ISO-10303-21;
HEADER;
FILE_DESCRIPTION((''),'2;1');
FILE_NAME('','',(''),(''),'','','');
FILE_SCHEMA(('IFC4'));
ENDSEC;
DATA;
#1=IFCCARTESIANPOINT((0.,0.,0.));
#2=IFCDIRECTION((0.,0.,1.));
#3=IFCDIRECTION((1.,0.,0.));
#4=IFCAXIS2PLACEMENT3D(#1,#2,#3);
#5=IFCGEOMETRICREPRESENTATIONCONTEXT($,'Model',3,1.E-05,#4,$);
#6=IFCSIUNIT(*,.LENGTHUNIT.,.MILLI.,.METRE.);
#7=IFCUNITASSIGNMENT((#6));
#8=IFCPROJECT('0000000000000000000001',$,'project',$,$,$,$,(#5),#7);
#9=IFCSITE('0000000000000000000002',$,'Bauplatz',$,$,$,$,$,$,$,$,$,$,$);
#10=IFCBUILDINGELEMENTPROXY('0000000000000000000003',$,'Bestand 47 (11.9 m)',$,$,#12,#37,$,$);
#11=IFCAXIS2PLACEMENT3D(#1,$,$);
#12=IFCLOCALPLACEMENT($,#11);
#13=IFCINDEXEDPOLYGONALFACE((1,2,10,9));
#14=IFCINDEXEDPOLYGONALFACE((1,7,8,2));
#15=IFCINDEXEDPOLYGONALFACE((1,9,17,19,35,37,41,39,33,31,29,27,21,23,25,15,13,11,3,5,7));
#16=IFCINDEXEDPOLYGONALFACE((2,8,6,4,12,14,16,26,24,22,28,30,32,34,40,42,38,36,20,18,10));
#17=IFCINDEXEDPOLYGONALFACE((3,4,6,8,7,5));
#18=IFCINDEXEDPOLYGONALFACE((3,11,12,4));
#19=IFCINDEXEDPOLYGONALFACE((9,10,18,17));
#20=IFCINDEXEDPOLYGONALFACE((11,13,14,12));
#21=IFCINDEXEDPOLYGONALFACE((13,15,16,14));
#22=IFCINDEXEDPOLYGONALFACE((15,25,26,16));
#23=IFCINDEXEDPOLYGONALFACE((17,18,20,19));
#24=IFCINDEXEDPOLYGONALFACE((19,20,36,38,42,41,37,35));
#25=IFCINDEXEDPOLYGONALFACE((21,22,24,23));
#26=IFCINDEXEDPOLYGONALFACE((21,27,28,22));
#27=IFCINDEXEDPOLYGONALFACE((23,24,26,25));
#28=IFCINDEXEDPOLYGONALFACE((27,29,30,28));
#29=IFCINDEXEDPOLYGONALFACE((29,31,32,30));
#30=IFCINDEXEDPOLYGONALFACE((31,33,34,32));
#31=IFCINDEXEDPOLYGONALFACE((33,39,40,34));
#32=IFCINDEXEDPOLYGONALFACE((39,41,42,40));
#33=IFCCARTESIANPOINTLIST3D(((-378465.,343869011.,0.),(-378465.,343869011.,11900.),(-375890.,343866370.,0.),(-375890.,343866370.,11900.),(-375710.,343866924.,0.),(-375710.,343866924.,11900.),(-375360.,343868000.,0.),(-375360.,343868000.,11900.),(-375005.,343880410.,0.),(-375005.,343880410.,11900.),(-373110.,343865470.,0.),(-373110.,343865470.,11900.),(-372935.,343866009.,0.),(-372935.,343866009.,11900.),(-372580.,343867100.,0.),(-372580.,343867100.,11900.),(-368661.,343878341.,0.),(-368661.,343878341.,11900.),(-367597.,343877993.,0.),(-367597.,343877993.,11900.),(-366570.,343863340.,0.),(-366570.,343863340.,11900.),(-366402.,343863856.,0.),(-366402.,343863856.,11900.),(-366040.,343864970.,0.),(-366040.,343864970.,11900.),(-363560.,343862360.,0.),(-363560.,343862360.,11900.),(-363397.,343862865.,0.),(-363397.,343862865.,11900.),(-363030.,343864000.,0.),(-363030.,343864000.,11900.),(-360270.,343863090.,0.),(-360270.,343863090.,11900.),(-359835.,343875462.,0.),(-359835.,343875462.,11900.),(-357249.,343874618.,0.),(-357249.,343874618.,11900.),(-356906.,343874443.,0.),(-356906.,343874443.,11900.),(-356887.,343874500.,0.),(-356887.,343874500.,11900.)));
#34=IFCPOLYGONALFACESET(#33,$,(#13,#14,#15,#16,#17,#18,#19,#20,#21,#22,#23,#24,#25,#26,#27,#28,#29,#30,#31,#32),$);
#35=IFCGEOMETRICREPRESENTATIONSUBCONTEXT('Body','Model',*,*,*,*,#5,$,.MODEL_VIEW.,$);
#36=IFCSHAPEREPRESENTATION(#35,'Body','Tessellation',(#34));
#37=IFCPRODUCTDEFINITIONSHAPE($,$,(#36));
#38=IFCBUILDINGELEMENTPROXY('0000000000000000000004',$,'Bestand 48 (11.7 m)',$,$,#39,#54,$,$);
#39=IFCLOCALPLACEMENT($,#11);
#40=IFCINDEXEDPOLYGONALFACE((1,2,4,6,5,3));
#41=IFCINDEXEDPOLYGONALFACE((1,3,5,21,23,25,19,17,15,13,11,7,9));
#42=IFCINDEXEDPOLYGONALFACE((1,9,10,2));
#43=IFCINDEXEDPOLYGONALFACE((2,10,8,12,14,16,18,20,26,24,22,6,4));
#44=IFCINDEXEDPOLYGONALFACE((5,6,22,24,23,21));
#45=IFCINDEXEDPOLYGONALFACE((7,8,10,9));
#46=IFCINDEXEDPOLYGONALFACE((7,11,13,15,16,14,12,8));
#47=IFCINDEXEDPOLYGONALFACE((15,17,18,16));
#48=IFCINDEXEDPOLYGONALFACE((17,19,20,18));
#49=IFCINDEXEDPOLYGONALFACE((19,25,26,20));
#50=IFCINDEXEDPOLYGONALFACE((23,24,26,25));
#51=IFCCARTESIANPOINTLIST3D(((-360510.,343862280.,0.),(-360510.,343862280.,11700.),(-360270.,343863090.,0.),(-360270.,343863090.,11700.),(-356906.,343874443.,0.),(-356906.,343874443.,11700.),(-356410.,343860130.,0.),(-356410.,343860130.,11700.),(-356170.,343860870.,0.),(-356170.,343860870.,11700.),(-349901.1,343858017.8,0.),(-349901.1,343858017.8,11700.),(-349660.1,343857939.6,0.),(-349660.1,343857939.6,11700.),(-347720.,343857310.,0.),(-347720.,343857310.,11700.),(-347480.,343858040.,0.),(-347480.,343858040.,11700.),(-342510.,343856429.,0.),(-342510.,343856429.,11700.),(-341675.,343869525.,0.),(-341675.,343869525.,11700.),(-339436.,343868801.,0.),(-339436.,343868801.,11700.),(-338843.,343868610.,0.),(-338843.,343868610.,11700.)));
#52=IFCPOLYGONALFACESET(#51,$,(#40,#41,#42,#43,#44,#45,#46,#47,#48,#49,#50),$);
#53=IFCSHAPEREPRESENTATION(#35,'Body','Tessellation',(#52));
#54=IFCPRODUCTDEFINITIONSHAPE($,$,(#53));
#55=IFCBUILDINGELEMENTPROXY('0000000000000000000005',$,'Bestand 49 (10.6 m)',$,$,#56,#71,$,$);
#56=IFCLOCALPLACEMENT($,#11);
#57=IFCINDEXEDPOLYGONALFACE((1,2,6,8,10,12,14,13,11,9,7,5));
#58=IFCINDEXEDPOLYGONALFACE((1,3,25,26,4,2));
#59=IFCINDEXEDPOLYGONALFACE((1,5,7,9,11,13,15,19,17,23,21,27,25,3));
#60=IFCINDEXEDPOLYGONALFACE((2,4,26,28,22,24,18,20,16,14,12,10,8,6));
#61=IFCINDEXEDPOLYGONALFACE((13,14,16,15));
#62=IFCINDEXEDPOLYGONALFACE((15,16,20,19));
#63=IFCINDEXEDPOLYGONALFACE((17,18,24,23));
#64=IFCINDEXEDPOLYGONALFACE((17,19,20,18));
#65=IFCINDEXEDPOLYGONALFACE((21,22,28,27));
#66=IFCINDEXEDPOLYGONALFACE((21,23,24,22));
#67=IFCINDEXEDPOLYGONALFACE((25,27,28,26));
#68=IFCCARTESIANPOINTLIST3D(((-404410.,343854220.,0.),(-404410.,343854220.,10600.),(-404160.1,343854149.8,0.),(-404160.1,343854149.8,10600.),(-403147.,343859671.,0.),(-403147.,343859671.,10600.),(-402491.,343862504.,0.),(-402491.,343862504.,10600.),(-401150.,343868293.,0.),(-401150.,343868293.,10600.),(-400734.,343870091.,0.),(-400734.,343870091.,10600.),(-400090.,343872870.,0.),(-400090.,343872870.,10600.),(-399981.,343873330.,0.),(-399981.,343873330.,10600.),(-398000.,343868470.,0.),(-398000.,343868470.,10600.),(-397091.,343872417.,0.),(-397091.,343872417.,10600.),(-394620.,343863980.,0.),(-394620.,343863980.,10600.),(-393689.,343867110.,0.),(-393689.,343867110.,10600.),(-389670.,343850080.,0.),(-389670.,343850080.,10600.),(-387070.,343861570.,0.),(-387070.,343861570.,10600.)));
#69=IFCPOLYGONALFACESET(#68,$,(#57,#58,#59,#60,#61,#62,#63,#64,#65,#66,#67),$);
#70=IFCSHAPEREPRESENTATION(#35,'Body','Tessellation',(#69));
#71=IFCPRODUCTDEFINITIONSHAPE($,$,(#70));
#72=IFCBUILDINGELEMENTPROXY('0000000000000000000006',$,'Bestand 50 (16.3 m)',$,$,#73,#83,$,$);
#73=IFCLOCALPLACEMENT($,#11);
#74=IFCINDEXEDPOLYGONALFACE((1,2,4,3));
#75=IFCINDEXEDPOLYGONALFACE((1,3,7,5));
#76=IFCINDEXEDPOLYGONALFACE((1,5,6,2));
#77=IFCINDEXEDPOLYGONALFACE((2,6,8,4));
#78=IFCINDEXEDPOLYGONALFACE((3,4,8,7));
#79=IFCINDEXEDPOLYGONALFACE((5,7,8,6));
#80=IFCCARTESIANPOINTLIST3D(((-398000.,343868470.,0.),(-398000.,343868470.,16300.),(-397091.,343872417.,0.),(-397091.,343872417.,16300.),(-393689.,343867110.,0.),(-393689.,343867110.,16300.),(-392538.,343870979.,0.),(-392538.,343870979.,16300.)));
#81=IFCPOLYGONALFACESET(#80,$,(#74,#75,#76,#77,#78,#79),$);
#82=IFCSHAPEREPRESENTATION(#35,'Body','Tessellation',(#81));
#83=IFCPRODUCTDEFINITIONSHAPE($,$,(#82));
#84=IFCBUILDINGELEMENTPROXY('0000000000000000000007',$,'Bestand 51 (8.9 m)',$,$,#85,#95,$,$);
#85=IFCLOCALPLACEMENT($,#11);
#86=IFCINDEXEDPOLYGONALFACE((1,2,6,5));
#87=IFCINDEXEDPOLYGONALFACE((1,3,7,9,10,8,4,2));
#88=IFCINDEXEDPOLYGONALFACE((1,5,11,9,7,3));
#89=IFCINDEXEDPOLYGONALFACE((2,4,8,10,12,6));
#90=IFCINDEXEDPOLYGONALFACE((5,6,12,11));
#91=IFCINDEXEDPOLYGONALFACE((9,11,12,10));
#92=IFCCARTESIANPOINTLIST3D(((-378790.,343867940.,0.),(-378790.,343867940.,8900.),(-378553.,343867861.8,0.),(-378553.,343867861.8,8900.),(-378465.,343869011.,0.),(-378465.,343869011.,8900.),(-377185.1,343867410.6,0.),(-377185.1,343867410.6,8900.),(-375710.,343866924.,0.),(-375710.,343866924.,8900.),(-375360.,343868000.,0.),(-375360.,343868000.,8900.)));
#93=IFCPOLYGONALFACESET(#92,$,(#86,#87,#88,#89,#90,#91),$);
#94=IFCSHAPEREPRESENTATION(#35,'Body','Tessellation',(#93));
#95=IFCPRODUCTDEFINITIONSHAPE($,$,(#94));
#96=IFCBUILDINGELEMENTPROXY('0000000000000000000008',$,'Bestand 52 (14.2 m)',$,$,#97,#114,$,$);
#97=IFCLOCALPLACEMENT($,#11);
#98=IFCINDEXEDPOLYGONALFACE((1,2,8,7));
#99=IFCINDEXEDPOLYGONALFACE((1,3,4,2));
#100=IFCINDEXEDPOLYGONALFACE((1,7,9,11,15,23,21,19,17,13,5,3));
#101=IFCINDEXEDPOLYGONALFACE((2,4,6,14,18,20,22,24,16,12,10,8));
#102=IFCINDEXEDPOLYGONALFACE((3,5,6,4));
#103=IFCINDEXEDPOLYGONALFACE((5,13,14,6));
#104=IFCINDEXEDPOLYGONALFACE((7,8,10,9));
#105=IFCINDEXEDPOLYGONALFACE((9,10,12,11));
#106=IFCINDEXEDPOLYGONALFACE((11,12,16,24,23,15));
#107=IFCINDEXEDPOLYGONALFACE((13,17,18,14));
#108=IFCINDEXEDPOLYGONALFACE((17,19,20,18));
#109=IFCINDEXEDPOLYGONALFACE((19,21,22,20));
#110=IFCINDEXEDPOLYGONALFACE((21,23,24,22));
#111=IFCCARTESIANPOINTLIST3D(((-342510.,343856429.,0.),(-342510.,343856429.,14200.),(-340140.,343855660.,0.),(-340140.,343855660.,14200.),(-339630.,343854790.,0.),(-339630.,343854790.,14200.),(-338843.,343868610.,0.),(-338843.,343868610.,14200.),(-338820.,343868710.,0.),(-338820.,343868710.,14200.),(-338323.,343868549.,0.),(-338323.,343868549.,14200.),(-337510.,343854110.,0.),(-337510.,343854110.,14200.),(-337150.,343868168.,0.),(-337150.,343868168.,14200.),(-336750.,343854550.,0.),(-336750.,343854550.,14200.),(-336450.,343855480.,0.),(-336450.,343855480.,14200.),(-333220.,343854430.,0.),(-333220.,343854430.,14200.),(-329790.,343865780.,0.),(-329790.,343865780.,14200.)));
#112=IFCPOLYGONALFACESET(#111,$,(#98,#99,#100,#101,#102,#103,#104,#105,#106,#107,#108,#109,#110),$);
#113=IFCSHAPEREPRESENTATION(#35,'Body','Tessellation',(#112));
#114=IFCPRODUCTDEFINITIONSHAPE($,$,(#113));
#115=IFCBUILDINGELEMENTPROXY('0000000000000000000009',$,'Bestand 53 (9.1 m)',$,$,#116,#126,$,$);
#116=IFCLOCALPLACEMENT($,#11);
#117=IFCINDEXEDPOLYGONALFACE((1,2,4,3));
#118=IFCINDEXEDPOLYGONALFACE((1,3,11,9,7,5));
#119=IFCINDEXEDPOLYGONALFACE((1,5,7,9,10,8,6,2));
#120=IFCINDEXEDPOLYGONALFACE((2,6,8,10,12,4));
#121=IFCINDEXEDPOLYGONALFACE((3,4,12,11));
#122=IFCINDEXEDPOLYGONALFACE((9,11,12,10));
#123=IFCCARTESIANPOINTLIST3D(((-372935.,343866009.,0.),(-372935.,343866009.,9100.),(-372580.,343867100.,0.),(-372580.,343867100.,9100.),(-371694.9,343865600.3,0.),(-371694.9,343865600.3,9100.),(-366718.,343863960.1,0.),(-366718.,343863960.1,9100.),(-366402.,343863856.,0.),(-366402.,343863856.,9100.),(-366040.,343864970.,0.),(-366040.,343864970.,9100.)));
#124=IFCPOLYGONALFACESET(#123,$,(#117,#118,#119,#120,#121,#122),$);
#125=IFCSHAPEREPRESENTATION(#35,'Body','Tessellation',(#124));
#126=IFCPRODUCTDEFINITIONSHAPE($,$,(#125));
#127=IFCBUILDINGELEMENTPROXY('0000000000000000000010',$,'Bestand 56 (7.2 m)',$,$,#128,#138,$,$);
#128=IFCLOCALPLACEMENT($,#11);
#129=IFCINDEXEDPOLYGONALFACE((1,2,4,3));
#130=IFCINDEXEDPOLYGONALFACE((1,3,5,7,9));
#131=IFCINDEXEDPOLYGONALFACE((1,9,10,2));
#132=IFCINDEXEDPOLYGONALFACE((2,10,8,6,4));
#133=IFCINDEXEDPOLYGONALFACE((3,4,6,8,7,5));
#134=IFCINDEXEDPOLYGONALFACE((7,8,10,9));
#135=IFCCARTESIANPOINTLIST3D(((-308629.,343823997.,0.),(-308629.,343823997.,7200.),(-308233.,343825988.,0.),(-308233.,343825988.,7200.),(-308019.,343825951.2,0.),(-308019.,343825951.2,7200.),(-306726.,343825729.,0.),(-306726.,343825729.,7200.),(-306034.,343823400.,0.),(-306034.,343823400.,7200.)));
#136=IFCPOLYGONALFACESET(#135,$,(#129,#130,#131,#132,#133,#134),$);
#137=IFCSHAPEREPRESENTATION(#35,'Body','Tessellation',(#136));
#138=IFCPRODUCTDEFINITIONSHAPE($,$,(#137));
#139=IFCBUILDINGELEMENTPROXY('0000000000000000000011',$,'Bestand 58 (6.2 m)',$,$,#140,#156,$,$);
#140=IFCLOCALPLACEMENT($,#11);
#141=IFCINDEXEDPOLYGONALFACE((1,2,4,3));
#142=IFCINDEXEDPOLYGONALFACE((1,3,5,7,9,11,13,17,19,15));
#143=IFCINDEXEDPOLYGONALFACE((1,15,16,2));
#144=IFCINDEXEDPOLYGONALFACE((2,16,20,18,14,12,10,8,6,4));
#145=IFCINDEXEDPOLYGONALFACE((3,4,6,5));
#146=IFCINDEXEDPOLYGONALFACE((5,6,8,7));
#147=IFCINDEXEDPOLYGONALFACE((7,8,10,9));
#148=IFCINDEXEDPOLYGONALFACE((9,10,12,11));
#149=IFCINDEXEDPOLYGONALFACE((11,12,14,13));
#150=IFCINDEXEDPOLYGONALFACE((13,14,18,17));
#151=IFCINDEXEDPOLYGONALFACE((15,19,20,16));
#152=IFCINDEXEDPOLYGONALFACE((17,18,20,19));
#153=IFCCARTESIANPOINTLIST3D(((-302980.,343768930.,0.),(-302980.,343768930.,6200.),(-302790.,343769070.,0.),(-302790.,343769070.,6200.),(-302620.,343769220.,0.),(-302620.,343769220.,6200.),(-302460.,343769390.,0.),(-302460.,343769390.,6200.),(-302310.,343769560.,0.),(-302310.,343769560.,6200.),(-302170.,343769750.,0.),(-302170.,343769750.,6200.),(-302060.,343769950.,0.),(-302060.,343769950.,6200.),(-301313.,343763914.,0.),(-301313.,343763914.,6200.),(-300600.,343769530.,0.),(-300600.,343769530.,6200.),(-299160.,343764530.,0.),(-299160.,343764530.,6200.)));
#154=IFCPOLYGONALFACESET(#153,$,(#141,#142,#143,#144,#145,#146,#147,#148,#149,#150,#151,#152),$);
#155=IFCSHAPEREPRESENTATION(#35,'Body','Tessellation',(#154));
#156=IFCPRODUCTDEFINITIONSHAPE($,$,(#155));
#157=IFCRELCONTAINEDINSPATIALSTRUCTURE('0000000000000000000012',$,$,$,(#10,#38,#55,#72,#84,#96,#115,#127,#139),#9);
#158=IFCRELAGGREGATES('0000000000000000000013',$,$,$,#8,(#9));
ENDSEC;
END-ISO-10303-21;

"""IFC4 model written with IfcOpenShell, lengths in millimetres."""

from ifc_helpers import new_model, si_unit, origin_with_axes, place, context, subcontext, project, spatial, indexed_curve, outline, extrude, element, save


model = new_model("IFC4")

# Units and contexts
model_context = context("Model", 3, precision=1e-05, world=origin_with_axes())
body_context = subcontext(model_context, "Body", "Model", "MODEL_VIEW")
ifc_project = project(units=[si_unit("LENGTHUNIT", "METRE", prefix="MILLI")], contexts=[model_context])

# Site
site = spatial("IfcSite", under=ifc_project, Name="Bauplatz")

# Building element proxies
proxy_1_placement = place(None, origin_with_axes())
element("IfcBuildingElementProxy", 1, at=proxy_1_placement, inside=site, Name="Bestand 47 (11.9 m)", context=body_context, shape_type="SweptSolid", body=[
    extrude(outline(indexed_curve([(-368661.0, 343878341.0), (-375005.0, 343880410.0), (-378465.0, 343869011.0), (-375360.0, 343868000.0), (-375710.0, 343866924.0), (-375890.0, 343866370.0), (-373110.0, 343865470.0), (-372935.0, 343866009.0), (-372580.0, 343867100.0), (-366040.0, 343864970.0), (-366402.0, 343863856.0), (-366570.0, 343863340.0), (-363560.0, 343862360.0), (-363397.0, 343862865.0), (-363030.0, 343864000.0), (-360270.0, 343863090.0), (-356906.0, 343874443.0), (-356887.0, 343874500.0), (-357249.0, 343874618.0), (-359835.0, 343875462.0), (-367597.0, 343877993.0)])), None, (0.0, 0.0, 1.0), 11900.0),
])
proxy_2_placement = place(None, origin_with_axes())
element("IfcBuildingElementProxy", 2, at=proxy_2_placement, inside=site, Name="Bestand 48 (11.7 m)", context=body_context, shape_type="SweptSolid", body=[
    extrude(outline(indexed_curve([(-341675.0, 343869525.0), (-356906.0, 343874443.0), (-360270.0, 343863090.0), (-360510.0, 343862280.0), (-356170.0, 343860870.0), (-356410.0, 343860130.0), (-349901.1, 343858017.8), (-349660.1, 343857939.6), (-347720.0, 343857310.0), (-347480.0, 343858040.0), (-342510.0, 343856429.0), (-338843.0, 343868610.0), (-339436.0, 343868801.0)])), None, (0.0, 0.0, 1.0), 11700.0),
])
proxy_3_placement = place(None, origin_with_axes())
element("IfcBuildingElementProxy", 3, at=proxy_3_placement, inside=site, Name="Bestand 49 (10.6 m)", context=body_context, shape_type="SweptSolid", body=[
    extrude(outline(indexed_curve([(-397091.0, 343872417.0), (-399981.0, 343873330.0), (-400090.0, 343872870.0), (-400734.0, 343870091.0), (-401150.0, 343868293.0), (-402491.0, 343862504.0), (-403147.0, 343859671.0), (-404410.0, 343854220.0), (-404160.1, 343854149.8), (-389670.0, 343850080.0), (-387070.0, 343861570.0), (-394620.0, 343863980.0), (-393689.0, 343867110.0), (-398000.0, 343868470.0)])), None, (0.0, 0.0, 1.0), 10600.0),
])
proxy_4_placement = place(None, origin_with_axes())
element("IfcBuildingElementProxy", 4, at=proxy_4_placement, inside=site, Name="Bestand 50 (16.3 m)", context=body_context, shape_type="SweptSolid", body=[
    extrude(outline(indexed_curve([(-392538.0, 343870979.0), (-397091.0, 343872417.0), (-398000.0, 343868470.0), (-393689.0, 343867110.0)])), None, (0.0, 0.0, 1.0), 16300.0),
])
proxy_5_placement = place(None, origin_with_axes())
element("IfcBuildingElementProxy", 5, at=proxy_5_placement, inside=site, Name="Bestand 51 (8.9 m)", context=body_context, shape_type="SweptSolid", body=[
    extrude(outline(indexed_curve([(-375360.0, 343868000.0), (-378465.0, 343869011.0), (-378790.0, 343867940.0), (-378553.0, 343867861.8), (-377185.1, 343867410.6), (-375710.0, 343866924.0)])), None, (0.0, 0.0, 1.0), 8900.0),
])
proxy_6_placement = place(None, origin_with_axes())
element("IfcBuildingElementProxy", 6, at=proxy_6_placement, inside=site, Name="Bestand 52 (14.2 m)", context=body_context, shape_type="SweptSolid", body=[
    extrude(outline(indexed_curve([(-338323.0, 343868549.0), (-338820.0, 343868710.0), (-338843.0, 343868610.0), (-342510.0, 343856429.0), (-340140.0, 343855660.0), (-339630.0, 343854790.0), (-337510.0, 343854110.0), (-336750.0, 343854550.0), (-336450.0, 343855480.0), (-333220.0, 343854430.0), (-329790.0, 343865780.0), (-337150.0, 343868168.0)])), None, (0.0, 0.0, 1.0), 14200.0),
])
proxy_7_placement = place(None, origin_with_axes())
element("IfcBuildingElementProxy", 7, at=proxy_7_placement, inside=site, Name="Bestand 53 (9.1 m)", context=body_context, shape_type="SweptSolid", body=[
    extrude(outline(indexed_curve([(-366040.0, 343864970.0), (-372580.0, 343867100.0), (-372935.0, 343866009.0), (-371694.9, 343865600.3), (-366718.0, 343863960.1), (-366402.0, 343863856.0)])), None, (0.0, 0.0, 1.0), 9100.0),
])
proxy_8_placement = place(None, origin_with_axes())
element("IfcBuildingElementProxy", 8, at=proxy_8_placement, inside=site, Name="Bestand 56 (7.2 m)", context=body_context, shape_type="SweptSolid", body=[
    extrude(outline(indexed_curve([(-308019.0, 343825951.2), (-308233.0, 343825988.0), (-308629.0, 343823997.0), (-306034.0, 343823400.0), (-306726.0, 343825729.0)])), None, (0.0, 0.0, 1.0), 7200.0),
])
proxy_9_placement = place(None, origin_with_axes())
element("IfcBuildingElementProxy", 9, at=proxy_9_placement, inside=site, Name="Bestand 58 (6.2 m)", context=body_context, shape_type="SweptSolid", body=[
    extrude(outline(indexed_curve([(-300600.0, 343769530.0), (-302060.0, 343769950.0), (-302170.0, 343769750.0), (-302310.0, 343769560.0), (-302460.0, 343769390.0), (-302620.0, 343769220.0), (-302790.0, 343769070.0), (-302980.0, 343768930.0), (-301313.0, 343763914.0), (-299160.0, 343764530.0)])), None, (0.0, 0.0, 1.0), 6200.0),
])

save(model, "model.ifc")
